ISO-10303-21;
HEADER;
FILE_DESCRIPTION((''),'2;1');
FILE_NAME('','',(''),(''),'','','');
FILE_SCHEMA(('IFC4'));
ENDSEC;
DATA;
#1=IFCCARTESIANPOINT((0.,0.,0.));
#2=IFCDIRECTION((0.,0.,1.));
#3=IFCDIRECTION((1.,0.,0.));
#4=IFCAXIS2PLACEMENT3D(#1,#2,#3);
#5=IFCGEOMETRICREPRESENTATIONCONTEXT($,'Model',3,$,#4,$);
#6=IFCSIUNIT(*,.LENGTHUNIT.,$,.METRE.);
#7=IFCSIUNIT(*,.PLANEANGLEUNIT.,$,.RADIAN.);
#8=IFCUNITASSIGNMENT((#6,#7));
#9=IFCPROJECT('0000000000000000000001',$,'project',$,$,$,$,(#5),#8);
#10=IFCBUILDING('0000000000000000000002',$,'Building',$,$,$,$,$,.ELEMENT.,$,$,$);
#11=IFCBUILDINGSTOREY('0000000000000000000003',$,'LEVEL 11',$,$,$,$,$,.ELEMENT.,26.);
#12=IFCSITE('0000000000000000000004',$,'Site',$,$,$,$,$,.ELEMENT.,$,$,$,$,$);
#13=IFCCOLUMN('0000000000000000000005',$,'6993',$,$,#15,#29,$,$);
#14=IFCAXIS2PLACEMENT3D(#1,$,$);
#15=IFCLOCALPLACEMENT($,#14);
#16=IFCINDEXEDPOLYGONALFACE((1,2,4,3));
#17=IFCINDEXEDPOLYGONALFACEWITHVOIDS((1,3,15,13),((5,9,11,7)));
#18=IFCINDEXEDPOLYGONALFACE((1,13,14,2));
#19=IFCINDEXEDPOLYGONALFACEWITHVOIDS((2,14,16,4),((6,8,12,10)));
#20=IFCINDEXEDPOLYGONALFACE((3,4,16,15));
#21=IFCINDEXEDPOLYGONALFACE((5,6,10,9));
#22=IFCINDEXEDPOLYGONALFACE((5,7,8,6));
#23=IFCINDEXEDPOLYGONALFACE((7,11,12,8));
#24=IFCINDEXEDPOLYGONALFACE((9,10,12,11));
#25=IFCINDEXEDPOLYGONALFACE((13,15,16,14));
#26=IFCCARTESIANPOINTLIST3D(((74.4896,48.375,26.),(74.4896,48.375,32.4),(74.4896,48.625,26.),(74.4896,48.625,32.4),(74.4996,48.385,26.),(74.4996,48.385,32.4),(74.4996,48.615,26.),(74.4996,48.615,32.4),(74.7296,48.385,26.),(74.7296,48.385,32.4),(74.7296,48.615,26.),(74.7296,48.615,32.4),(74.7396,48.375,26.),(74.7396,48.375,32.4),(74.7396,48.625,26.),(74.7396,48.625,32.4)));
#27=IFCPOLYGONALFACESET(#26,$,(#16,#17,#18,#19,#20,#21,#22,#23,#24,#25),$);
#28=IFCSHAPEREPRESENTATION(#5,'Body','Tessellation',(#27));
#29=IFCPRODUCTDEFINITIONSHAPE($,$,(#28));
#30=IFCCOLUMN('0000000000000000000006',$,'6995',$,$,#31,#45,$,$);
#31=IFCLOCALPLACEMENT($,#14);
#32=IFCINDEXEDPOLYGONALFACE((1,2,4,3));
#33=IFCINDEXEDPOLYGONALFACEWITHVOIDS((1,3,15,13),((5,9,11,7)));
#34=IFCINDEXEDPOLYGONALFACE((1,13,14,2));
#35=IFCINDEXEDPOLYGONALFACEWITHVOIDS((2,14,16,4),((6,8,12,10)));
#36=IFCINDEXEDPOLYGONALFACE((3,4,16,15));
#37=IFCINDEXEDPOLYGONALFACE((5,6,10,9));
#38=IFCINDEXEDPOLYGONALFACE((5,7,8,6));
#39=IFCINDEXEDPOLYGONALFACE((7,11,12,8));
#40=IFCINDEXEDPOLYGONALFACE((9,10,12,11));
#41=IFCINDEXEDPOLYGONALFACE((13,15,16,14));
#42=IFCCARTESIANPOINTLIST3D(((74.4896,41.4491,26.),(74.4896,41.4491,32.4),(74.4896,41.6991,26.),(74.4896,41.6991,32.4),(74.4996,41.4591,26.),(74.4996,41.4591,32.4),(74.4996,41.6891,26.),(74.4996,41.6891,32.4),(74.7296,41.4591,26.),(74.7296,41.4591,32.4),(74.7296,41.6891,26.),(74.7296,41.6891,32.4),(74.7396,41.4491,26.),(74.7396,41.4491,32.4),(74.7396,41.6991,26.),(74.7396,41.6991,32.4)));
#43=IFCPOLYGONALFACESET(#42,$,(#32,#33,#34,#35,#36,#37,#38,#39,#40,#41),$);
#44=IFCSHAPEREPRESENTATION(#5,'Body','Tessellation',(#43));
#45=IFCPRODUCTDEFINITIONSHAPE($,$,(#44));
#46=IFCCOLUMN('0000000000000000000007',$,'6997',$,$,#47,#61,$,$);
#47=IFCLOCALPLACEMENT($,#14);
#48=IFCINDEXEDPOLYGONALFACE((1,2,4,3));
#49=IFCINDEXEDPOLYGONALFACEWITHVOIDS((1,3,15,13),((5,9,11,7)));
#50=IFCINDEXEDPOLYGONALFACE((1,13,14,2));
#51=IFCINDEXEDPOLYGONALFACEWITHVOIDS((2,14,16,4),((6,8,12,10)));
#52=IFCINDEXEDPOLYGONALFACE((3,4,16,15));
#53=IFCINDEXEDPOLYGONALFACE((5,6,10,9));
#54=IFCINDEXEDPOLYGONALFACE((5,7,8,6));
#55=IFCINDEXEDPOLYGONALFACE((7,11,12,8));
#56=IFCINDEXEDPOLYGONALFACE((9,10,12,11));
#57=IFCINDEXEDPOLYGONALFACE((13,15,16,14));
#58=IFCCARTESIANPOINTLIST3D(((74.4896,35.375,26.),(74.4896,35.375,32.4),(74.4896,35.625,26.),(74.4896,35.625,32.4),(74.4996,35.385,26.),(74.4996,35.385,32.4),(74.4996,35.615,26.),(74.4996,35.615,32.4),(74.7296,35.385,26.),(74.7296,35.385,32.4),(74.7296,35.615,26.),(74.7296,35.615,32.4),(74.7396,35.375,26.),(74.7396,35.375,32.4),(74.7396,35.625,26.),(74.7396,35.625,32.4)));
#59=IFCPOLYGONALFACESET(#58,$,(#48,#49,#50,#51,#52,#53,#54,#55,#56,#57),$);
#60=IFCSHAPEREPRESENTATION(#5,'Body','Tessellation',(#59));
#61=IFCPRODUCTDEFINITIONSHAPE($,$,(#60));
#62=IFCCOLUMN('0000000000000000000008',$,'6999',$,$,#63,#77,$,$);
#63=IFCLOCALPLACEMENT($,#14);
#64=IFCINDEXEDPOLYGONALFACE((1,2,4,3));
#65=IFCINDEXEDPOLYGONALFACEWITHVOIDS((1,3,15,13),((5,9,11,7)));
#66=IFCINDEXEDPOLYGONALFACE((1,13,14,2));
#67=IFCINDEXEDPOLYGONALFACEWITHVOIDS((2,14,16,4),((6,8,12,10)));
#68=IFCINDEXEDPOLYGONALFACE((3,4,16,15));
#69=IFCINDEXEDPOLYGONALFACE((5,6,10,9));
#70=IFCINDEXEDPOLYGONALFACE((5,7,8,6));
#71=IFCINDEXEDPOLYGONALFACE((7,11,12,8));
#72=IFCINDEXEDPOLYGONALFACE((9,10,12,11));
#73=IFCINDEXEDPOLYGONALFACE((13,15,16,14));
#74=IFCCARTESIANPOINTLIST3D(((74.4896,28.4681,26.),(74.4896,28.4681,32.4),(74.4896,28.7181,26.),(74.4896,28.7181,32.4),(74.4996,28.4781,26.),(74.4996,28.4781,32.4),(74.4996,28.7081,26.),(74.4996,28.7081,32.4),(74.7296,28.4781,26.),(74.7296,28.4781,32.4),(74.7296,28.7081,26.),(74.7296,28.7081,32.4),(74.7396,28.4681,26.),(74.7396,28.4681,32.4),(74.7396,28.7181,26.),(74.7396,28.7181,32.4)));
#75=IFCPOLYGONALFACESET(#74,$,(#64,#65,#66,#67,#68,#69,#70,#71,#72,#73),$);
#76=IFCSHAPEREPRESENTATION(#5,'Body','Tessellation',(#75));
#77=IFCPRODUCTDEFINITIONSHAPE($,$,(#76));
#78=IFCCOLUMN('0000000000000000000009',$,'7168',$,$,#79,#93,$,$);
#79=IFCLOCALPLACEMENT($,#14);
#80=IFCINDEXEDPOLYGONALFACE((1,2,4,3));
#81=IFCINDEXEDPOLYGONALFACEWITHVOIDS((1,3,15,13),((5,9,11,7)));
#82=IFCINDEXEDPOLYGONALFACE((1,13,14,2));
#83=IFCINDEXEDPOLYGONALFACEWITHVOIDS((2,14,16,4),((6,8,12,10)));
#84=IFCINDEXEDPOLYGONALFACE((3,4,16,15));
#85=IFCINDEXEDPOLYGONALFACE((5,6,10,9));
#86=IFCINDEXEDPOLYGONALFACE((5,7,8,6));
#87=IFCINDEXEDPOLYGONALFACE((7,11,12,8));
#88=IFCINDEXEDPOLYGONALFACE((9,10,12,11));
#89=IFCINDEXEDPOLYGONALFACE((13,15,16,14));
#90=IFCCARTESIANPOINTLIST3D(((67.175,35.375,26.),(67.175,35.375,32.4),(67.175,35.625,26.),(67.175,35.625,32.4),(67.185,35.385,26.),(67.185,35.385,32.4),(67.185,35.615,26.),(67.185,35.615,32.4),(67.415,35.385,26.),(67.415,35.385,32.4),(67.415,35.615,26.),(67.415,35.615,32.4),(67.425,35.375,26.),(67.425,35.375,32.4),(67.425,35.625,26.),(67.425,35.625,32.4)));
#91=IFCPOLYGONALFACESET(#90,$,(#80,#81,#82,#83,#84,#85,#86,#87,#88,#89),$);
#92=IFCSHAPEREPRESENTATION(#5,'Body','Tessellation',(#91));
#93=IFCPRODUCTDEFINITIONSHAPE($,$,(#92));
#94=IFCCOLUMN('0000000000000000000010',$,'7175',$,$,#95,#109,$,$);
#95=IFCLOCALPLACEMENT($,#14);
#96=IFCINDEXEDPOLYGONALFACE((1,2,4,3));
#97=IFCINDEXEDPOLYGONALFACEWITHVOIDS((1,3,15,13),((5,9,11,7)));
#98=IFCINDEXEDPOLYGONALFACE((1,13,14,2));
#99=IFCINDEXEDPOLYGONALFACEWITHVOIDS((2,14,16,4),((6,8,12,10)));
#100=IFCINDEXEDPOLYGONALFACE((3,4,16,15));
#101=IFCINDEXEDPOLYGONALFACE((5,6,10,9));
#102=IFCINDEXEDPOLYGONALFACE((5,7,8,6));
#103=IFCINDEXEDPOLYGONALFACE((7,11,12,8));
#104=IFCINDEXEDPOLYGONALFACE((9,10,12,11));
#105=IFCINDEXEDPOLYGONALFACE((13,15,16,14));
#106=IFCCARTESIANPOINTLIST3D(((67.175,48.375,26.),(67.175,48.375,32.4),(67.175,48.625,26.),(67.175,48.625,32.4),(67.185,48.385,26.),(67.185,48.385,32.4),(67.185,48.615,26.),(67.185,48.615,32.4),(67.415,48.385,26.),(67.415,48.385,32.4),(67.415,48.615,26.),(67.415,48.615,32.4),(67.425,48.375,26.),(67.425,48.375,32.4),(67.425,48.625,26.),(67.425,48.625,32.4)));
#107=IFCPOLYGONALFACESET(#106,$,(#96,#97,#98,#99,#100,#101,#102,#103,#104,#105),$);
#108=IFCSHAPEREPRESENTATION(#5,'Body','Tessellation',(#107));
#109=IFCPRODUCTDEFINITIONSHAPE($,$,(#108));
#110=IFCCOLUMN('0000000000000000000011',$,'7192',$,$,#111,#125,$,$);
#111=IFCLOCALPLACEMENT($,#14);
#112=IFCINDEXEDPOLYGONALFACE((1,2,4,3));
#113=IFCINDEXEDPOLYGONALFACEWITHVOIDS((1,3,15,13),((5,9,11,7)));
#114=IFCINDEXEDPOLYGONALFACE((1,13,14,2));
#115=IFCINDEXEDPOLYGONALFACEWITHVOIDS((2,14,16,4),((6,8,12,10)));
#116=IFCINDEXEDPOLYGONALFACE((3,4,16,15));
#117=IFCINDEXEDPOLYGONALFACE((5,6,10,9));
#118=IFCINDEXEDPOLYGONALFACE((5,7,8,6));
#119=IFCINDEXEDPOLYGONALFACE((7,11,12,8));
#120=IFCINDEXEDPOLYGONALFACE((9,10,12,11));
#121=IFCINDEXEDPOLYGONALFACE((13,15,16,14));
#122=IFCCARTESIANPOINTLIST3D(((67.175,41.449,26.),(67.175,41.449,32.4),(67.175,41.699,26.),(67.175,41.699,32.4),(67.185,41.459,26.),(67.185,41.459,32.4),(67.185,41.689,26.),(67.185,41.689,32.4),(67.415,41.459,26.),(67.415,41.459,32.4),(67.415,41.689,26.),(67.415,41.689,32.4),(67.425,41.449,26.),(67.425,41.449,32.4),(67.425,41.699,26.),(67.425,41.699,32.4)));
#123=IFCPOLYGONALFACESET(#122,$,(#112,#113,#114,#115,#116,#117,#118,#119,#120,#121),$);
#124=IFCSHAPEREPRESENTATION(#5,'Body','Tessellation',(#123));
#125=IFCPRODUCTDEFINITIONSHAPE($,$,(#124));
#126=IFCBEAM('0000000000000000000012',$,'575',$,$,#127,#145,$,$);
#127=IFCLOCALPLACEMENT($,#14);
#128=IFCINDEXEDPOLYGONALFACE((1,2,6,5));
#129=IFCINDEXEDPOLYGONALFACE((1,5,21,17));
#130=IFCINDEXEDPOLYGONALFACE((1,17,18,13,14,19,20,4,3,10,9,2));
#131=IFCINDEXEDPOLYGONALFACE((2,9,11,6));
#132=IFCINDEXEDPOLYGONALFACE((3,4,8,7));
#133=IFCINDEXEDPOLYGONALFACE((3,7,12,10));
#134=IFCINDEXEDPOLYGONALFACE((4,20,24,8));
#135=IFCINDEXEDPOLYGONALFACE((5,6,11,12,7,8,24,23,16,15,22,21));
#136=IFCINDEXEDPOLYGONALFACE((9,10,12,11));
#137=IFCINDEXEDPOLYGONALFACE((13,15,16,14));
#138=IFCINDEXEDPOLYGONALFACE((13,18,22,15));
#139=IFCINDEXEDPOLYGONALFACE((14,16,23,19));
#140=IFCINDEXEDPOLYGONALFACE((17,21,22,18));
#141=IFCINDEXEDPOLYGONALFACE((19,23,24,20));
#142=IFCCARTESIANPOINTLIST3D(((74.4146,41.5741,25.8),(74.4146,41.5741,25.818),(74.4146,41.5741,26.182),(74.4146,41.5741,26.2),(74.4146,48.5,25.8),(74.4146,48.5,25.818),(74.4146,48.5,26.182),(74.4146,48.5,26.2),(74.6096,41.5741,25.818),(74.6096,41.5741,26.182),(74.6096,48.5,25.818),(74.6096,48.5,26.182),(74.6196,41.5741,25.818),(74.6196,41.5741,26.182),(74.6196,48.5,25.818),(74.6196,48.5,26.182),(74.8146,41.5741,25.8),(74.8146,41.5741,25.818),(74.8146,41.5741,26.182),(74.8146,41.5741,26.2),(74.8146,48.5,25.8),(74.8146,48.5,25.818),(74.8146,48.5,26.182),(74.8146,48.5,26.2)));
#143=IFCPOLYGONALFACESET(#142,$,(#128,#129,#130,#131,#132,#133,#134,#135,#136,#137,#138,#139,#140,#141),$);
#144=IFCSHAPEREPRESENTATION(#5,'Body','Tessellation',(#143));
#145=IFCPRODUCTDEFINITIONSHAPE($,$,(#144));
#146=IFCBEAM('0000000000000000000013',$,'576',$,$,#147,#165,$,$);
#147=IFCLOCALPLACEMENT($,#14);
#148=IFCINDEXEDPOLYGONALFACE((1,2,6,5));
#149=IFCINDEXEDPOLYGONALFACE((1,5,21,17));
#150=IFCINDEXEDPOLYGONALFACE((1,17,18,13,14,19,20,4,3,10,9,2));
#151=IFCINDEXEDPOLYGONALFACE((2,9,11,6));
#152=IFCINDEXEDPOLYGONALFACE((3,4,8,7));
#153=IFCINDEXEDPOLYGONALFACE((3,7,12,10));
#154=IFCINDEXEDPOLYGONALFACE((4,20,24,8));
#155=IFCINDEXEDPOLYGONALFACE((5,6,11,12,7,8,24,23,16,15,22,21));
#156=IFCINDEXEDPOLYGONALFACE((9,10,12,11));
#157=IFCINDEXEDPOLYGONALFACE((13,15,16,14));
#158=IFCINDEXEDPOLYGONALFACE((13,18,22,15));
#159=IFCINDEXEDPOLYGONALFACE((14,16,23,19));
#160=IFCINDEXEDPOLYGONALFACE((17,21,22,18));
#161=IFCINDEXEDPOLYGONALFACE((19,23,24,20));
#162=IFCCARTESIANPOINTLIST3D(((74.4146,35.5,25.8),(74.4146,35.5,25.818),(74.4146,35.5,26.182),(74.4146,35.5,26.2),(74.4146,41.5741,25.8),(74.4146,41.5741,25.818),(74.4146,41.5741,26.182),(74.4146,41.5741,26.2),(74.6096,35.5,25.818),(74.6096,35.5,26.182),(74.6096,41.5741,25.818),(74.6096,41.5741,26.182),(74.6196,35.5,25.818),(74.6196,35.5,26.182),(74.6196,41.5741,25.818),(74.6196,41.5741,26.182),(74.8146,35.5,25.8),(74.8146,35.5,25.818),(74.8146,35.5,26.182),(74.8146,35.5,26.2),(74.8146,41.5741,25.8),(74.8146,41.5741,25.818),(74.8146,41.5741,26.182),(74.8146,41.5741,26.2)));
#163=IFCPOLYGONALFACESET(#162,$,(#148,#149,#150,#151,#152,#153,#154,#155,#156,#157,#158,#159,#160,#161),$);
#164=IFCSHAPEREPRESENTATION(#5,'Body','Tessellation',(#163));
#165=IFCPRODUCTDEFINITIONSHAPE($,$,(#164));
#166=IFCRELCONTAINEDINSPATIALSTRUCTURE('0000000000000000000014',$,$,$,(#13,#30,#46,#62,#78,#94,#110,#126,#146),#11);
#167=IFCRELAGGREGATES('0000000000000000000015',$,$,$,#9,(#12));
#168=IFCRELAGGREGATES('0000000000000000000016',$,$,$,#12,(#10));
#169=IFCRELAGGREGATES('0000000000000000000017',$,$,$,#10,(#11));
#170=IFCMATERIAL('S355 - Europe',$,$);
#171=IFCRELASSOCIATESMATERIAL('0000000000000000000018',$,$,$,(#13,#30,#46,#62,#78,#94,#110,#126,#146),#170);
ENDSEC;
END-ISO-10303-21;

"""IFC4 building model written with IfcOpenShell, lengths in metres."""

from ifc_helpers import new_model, si_unit, frame, origin_with_axes, origin_2d_with_axis, place, context, project, spatial, hollow_rectangle, i_section, extrude, material, material_profile, profile_set, profile_usage, element, save


model = new_model("IFC4")

# Units and contexts
model_context = context("Model", 3, world=origin_with_axes())
ifc_project = project(units=[si_unit("LENGTHUNIT", "METRE"), si_unit("PLANEANGLEUNIT", "RADIAN")], contexts=[model_context])

# Site, building, storey
site = spatial("IfcSite", under=ifc_project, Name="Site", CompositionType="ELEMENT")
building = spatial("IfcBuilding", under=site, Name="Building", CompositionType="ELEMENT")
storey = spatial("IfcBuildingStorey", under=building, Name="LEVEL 11", CompositionType="ELEMENT", Elevation=26.0)

# Columns
ifc_material = material(Name="S355 - Europe")
ifc_material_profile_1 = material_profile(ifc_material, hollow_rectangle(XDim=0.25, YDim=0.25, WallThickness=0.01, at=origin_2d_with_axis()))
ifc_profile_set_1 = profile_set([ifc_material_profile_1])
ifc_profile_usage_1 = profile_usage(ifc_profile_set_1, cardinal=10)
column_1_placement = place(None, frame((74.6146, 48.5, 26.0), z_axis=(0.0, 0.0, 1.0), x_axis=(0.0, -1.0, 0.0)))
element("IfcColumn", 1, at=column_1_placement, inside=storey, material=ifc_profile_usage_1, Name="6993", context=model_context, shape_type="SweptSolid", body=[
    extrude(hollow_rectangle(XDim=0.25, YDim=0.25, WallThickness=0.01, at=origin_2d_with_axis()), origin_with_axes(), (0.0, 0.0, 1.0), 6.4),
])
ifc_material_profile_2 = material_profile(ifc_material, hollow_rectangle(XDim=0.25, YDim=0.25, WallThickness=0.01, at=origin_2d_with_axis()))
ifc_profile_set_2 = profile_set([ifc_material_profile_2])
ifc_profile_usage_2 = profile_usage(ifc_profile_set_2, cardinal=10)
column_2_placement = place(None, frame((74.6146, 41.5741, 26.0), z_axis=(0.0, 0.0, 1.0), x_axis=(0.0, -1.0, 0.0)))
element("IfcColumn", 2, at=column_2_placement, inside=storey, material=ifc_profile_usage_2, Name="6995", context=model_context, shape_type="SweptSolid", body=[
    extrude(hollow_rectangle(XDim=0.25, YDim=0.25, WallThickness=0.01, at=origin_2d_with_axis()), origin_with_axes(), (0.0, 0.0, 1.0), 6.4),
])
ifc_material_profile_3 = material_profile(ifc_material, hollow_rectangle(XDim=0.25, YDim=0.25, WallThickness=0.01, at=origin_2d_with_axis()))
ifc_profile_set_3 = profile_set([ifc_material_profile_3])
ifc_profile_usage_3 = profile_usage(ifc_profile_set_3, cardinal=10)
column_3_placement = place(None, frame((74.6146, 35.5, 26.0), z_axis=(0.0, 0.0, 1.0), x_axis=(0.0, -1.0, 0.0)))
element("IfcColumn", 3, at=column_3_placement, inside=storey, material=ifc_profile_usage_3, Name="6997", context=model_context, shape_type="SweptSolid", body=[
    extrude(hollow_rectangle(XDim=0.25, YDim=0.25, WallThickness=0.01, at=origin_2d_with_axis()), origin_with_axes(), (0.0, 0.0, 1.0), 6.4),
])
ifc_material_profile_4 = material_profile(ifc_material, hollow_rectangle(XDim=0.25, YDim=0.25, WallThickness=0.01, at=origin_2d_with_axis()))
ifc_profile_set_4 = profile_set([ifc_material_profile_4])
ifc_profile_usage_4 = profile_usage(ifc_profile_set_4, cardinal=10)
column_4_placement = place(None, frame((74.6146, 28.5931, 26.0), z_axis=(0.0, 0.0, 1.0), x_axis=(0.0, -1.0, 0.0)))
element("IfcColumn", 4, at=column_4_placement, inside=storey, material=ifc_profile_usage_4, Name="6999", context=model_context, shape_type="SweptSolid", body=[
    extrude(hollow_rectangle(XDim=0.25, YDim=0.25, WallThickness=0.01, at=origin_2d_with_axis()), origin_with_axes(), (0.0, 0.0, 1.0), 6.4),
])
ifc_material_profile_5 = material_profile(ifc_material, hollow_rectangle(XDim=0.25, YDim=0.25, WallThickness=0.01, at=origin_2d_with_axis()))
ifc_profile_set_5 = profile_set([ifc_material_profile_5])
ifc_profile_usage_5 = profile_usage(ifc_profile_set_5, cardinal=10)
column_5_placement = place(None, frame((67.3, 35.5, 26.0), z_axis=(0.0, 0.0, 1.0), x_axis=(0.0, -1.0, 0.0)))
element("IfcColumn", 5, at=column_5_placement, inside=storey, material=ifc_profile_usage_5, Name="7168", context=model_context, shape_type="SweptSolid", body=[
    extrude(hollow_rectangle(XDim=0.25, YDim=0.25, WallThickness=0.01, at=origin_2d_with_axis()), origin_with_axes(), (0.0, 0.0, 1.0), 6.4),
])
ifc_material_profile_6 = material_profile(ifc_material, hollow_rectangle(XDim=0.25, YDim=0.25, WallThickness=0.01, at=origin_2d_with_axis()))
ifc_profile_set_6 = profile_set([ifc_material_profile_6])
ifc_profile_usage_6 = profile_usage(ifc_profile_set_6, cardinal=10)
column_6_placement = place(None, frame((67.3, 48.5, 26.0), z_axis=(0.0, 0.0, 1.0), x_axis=(0.0, -1.0, 0.0)))
element("IfcColumn", 6, at=column_6_placement, inside=storey, material=ifc_profile_usage_6, Name="7175", context=model_context, shape_type="SweptSolid", body=[
    extrude(hollow_rectangle(XDim=0.25, YDim=0.25, WallThickness=0.01, at=origin_2d_with_axis()), origin_with_axes(), (0.0, 0.0, 1.0), 6.4),
])
ifc_material_profile_7 = material_profile(ifc_material, hollow_rectangle(XDim=0.25, YDim=0.25, WallThickness=0.01, at=origin_2d_with_axis()))
ifc_profile_set_7 = profile_set([ifc_material_profile_7])
ifc_profile_usage_7 = profile_usage(ifc_profile_set_7, cardinal=10)
column_7_placement = place(None, frame((67.3, 41.574, 26.0), z_axis=(0.0, 0.0, 1.0), x_axis=(0.0, -1.0, 0.0)))
element("IfcColumn", 7, at=column_7_placement, inside=storey, material=ifc_profile_usage_7, Name="7192", context=model_context, shape_type="SweptSolid", body=[
    extrude(hollow_rectangle(XDim=0.25, YDim=0.25, WallThickness=0.01, at=origin_2d_with_axis()), origin_with_axes(), (0.0, 0.0, 1.0), 6.4),
])

# Beams
ifc_material_profile_8 = material_profile(ifc_material, i_section(OverallWidth=0.4, OverallDepth=0.4, WebThickness=0.01, FlangeThickness=0.018, at=origin_2d_with_axis()))
ifc_profile_set_8 = profile_set([ifc_material_profile_8])
ifc_profile_usage_8 = profile_usage(ifc_profile_set_8, cardinal=10)
beam_1_placement = place(None, frame((74.6146, 48.5, 26.0), z_axis=(0.0, -1.0, 0.0), x_axis=(1.0, 0.0, 0.0)))
element("IfcBeam", 8, at=beam_1_placement, inside=storey, material=ifc_profile_usage_8, Name="575", context=model_context, shape_type="SweptSolid", body=[
    extrude(i_section(OverallWidth=0.4, OverallDepth=0.4, WebThickness=0.01, FlangeThickness=0.018, at=origin_2d_with_axis()), origin_with_axes(), (0.0, 0.0, 1.0), 6.9259),
])
ifc_material_profile_9 = material_profile(ifc_material, i_section(OverallWidth=0.4, OverallDepth=0.4, WebThickness=0.01, FlangeThickness=0.018, at=origin_2d_with_axis()))
ifc_profile_set_9 = profile_set([ifc_material_profile_9])
ifc_profile_usage_9 = profile_usage(ifc_profile_set_9, cardinal=10)
beam_2_placement = place(None, frame((74.6146, 41.5741, 26.0), z_axis=(0.0, -1.0, 0.0), x_axis=(1.0, 0.0, 0.0)))
element("IfcBeam", 9, at=beam_2_placement, inside=storey, material=ifc_profile_usage_9, Name="576", context=model_context, shape_type="SweptSolid", body=[
    extrude(i_section(OverallWidth=0.4, OverallDepth=0.4, WebThickness=0.01, FlangeThickness=0.018, at=origin_2d_with_axis()), origin_with_axes(), (0.0, 0.0, 1.0), 6.0741),
])

save(model, "model.ifc")
